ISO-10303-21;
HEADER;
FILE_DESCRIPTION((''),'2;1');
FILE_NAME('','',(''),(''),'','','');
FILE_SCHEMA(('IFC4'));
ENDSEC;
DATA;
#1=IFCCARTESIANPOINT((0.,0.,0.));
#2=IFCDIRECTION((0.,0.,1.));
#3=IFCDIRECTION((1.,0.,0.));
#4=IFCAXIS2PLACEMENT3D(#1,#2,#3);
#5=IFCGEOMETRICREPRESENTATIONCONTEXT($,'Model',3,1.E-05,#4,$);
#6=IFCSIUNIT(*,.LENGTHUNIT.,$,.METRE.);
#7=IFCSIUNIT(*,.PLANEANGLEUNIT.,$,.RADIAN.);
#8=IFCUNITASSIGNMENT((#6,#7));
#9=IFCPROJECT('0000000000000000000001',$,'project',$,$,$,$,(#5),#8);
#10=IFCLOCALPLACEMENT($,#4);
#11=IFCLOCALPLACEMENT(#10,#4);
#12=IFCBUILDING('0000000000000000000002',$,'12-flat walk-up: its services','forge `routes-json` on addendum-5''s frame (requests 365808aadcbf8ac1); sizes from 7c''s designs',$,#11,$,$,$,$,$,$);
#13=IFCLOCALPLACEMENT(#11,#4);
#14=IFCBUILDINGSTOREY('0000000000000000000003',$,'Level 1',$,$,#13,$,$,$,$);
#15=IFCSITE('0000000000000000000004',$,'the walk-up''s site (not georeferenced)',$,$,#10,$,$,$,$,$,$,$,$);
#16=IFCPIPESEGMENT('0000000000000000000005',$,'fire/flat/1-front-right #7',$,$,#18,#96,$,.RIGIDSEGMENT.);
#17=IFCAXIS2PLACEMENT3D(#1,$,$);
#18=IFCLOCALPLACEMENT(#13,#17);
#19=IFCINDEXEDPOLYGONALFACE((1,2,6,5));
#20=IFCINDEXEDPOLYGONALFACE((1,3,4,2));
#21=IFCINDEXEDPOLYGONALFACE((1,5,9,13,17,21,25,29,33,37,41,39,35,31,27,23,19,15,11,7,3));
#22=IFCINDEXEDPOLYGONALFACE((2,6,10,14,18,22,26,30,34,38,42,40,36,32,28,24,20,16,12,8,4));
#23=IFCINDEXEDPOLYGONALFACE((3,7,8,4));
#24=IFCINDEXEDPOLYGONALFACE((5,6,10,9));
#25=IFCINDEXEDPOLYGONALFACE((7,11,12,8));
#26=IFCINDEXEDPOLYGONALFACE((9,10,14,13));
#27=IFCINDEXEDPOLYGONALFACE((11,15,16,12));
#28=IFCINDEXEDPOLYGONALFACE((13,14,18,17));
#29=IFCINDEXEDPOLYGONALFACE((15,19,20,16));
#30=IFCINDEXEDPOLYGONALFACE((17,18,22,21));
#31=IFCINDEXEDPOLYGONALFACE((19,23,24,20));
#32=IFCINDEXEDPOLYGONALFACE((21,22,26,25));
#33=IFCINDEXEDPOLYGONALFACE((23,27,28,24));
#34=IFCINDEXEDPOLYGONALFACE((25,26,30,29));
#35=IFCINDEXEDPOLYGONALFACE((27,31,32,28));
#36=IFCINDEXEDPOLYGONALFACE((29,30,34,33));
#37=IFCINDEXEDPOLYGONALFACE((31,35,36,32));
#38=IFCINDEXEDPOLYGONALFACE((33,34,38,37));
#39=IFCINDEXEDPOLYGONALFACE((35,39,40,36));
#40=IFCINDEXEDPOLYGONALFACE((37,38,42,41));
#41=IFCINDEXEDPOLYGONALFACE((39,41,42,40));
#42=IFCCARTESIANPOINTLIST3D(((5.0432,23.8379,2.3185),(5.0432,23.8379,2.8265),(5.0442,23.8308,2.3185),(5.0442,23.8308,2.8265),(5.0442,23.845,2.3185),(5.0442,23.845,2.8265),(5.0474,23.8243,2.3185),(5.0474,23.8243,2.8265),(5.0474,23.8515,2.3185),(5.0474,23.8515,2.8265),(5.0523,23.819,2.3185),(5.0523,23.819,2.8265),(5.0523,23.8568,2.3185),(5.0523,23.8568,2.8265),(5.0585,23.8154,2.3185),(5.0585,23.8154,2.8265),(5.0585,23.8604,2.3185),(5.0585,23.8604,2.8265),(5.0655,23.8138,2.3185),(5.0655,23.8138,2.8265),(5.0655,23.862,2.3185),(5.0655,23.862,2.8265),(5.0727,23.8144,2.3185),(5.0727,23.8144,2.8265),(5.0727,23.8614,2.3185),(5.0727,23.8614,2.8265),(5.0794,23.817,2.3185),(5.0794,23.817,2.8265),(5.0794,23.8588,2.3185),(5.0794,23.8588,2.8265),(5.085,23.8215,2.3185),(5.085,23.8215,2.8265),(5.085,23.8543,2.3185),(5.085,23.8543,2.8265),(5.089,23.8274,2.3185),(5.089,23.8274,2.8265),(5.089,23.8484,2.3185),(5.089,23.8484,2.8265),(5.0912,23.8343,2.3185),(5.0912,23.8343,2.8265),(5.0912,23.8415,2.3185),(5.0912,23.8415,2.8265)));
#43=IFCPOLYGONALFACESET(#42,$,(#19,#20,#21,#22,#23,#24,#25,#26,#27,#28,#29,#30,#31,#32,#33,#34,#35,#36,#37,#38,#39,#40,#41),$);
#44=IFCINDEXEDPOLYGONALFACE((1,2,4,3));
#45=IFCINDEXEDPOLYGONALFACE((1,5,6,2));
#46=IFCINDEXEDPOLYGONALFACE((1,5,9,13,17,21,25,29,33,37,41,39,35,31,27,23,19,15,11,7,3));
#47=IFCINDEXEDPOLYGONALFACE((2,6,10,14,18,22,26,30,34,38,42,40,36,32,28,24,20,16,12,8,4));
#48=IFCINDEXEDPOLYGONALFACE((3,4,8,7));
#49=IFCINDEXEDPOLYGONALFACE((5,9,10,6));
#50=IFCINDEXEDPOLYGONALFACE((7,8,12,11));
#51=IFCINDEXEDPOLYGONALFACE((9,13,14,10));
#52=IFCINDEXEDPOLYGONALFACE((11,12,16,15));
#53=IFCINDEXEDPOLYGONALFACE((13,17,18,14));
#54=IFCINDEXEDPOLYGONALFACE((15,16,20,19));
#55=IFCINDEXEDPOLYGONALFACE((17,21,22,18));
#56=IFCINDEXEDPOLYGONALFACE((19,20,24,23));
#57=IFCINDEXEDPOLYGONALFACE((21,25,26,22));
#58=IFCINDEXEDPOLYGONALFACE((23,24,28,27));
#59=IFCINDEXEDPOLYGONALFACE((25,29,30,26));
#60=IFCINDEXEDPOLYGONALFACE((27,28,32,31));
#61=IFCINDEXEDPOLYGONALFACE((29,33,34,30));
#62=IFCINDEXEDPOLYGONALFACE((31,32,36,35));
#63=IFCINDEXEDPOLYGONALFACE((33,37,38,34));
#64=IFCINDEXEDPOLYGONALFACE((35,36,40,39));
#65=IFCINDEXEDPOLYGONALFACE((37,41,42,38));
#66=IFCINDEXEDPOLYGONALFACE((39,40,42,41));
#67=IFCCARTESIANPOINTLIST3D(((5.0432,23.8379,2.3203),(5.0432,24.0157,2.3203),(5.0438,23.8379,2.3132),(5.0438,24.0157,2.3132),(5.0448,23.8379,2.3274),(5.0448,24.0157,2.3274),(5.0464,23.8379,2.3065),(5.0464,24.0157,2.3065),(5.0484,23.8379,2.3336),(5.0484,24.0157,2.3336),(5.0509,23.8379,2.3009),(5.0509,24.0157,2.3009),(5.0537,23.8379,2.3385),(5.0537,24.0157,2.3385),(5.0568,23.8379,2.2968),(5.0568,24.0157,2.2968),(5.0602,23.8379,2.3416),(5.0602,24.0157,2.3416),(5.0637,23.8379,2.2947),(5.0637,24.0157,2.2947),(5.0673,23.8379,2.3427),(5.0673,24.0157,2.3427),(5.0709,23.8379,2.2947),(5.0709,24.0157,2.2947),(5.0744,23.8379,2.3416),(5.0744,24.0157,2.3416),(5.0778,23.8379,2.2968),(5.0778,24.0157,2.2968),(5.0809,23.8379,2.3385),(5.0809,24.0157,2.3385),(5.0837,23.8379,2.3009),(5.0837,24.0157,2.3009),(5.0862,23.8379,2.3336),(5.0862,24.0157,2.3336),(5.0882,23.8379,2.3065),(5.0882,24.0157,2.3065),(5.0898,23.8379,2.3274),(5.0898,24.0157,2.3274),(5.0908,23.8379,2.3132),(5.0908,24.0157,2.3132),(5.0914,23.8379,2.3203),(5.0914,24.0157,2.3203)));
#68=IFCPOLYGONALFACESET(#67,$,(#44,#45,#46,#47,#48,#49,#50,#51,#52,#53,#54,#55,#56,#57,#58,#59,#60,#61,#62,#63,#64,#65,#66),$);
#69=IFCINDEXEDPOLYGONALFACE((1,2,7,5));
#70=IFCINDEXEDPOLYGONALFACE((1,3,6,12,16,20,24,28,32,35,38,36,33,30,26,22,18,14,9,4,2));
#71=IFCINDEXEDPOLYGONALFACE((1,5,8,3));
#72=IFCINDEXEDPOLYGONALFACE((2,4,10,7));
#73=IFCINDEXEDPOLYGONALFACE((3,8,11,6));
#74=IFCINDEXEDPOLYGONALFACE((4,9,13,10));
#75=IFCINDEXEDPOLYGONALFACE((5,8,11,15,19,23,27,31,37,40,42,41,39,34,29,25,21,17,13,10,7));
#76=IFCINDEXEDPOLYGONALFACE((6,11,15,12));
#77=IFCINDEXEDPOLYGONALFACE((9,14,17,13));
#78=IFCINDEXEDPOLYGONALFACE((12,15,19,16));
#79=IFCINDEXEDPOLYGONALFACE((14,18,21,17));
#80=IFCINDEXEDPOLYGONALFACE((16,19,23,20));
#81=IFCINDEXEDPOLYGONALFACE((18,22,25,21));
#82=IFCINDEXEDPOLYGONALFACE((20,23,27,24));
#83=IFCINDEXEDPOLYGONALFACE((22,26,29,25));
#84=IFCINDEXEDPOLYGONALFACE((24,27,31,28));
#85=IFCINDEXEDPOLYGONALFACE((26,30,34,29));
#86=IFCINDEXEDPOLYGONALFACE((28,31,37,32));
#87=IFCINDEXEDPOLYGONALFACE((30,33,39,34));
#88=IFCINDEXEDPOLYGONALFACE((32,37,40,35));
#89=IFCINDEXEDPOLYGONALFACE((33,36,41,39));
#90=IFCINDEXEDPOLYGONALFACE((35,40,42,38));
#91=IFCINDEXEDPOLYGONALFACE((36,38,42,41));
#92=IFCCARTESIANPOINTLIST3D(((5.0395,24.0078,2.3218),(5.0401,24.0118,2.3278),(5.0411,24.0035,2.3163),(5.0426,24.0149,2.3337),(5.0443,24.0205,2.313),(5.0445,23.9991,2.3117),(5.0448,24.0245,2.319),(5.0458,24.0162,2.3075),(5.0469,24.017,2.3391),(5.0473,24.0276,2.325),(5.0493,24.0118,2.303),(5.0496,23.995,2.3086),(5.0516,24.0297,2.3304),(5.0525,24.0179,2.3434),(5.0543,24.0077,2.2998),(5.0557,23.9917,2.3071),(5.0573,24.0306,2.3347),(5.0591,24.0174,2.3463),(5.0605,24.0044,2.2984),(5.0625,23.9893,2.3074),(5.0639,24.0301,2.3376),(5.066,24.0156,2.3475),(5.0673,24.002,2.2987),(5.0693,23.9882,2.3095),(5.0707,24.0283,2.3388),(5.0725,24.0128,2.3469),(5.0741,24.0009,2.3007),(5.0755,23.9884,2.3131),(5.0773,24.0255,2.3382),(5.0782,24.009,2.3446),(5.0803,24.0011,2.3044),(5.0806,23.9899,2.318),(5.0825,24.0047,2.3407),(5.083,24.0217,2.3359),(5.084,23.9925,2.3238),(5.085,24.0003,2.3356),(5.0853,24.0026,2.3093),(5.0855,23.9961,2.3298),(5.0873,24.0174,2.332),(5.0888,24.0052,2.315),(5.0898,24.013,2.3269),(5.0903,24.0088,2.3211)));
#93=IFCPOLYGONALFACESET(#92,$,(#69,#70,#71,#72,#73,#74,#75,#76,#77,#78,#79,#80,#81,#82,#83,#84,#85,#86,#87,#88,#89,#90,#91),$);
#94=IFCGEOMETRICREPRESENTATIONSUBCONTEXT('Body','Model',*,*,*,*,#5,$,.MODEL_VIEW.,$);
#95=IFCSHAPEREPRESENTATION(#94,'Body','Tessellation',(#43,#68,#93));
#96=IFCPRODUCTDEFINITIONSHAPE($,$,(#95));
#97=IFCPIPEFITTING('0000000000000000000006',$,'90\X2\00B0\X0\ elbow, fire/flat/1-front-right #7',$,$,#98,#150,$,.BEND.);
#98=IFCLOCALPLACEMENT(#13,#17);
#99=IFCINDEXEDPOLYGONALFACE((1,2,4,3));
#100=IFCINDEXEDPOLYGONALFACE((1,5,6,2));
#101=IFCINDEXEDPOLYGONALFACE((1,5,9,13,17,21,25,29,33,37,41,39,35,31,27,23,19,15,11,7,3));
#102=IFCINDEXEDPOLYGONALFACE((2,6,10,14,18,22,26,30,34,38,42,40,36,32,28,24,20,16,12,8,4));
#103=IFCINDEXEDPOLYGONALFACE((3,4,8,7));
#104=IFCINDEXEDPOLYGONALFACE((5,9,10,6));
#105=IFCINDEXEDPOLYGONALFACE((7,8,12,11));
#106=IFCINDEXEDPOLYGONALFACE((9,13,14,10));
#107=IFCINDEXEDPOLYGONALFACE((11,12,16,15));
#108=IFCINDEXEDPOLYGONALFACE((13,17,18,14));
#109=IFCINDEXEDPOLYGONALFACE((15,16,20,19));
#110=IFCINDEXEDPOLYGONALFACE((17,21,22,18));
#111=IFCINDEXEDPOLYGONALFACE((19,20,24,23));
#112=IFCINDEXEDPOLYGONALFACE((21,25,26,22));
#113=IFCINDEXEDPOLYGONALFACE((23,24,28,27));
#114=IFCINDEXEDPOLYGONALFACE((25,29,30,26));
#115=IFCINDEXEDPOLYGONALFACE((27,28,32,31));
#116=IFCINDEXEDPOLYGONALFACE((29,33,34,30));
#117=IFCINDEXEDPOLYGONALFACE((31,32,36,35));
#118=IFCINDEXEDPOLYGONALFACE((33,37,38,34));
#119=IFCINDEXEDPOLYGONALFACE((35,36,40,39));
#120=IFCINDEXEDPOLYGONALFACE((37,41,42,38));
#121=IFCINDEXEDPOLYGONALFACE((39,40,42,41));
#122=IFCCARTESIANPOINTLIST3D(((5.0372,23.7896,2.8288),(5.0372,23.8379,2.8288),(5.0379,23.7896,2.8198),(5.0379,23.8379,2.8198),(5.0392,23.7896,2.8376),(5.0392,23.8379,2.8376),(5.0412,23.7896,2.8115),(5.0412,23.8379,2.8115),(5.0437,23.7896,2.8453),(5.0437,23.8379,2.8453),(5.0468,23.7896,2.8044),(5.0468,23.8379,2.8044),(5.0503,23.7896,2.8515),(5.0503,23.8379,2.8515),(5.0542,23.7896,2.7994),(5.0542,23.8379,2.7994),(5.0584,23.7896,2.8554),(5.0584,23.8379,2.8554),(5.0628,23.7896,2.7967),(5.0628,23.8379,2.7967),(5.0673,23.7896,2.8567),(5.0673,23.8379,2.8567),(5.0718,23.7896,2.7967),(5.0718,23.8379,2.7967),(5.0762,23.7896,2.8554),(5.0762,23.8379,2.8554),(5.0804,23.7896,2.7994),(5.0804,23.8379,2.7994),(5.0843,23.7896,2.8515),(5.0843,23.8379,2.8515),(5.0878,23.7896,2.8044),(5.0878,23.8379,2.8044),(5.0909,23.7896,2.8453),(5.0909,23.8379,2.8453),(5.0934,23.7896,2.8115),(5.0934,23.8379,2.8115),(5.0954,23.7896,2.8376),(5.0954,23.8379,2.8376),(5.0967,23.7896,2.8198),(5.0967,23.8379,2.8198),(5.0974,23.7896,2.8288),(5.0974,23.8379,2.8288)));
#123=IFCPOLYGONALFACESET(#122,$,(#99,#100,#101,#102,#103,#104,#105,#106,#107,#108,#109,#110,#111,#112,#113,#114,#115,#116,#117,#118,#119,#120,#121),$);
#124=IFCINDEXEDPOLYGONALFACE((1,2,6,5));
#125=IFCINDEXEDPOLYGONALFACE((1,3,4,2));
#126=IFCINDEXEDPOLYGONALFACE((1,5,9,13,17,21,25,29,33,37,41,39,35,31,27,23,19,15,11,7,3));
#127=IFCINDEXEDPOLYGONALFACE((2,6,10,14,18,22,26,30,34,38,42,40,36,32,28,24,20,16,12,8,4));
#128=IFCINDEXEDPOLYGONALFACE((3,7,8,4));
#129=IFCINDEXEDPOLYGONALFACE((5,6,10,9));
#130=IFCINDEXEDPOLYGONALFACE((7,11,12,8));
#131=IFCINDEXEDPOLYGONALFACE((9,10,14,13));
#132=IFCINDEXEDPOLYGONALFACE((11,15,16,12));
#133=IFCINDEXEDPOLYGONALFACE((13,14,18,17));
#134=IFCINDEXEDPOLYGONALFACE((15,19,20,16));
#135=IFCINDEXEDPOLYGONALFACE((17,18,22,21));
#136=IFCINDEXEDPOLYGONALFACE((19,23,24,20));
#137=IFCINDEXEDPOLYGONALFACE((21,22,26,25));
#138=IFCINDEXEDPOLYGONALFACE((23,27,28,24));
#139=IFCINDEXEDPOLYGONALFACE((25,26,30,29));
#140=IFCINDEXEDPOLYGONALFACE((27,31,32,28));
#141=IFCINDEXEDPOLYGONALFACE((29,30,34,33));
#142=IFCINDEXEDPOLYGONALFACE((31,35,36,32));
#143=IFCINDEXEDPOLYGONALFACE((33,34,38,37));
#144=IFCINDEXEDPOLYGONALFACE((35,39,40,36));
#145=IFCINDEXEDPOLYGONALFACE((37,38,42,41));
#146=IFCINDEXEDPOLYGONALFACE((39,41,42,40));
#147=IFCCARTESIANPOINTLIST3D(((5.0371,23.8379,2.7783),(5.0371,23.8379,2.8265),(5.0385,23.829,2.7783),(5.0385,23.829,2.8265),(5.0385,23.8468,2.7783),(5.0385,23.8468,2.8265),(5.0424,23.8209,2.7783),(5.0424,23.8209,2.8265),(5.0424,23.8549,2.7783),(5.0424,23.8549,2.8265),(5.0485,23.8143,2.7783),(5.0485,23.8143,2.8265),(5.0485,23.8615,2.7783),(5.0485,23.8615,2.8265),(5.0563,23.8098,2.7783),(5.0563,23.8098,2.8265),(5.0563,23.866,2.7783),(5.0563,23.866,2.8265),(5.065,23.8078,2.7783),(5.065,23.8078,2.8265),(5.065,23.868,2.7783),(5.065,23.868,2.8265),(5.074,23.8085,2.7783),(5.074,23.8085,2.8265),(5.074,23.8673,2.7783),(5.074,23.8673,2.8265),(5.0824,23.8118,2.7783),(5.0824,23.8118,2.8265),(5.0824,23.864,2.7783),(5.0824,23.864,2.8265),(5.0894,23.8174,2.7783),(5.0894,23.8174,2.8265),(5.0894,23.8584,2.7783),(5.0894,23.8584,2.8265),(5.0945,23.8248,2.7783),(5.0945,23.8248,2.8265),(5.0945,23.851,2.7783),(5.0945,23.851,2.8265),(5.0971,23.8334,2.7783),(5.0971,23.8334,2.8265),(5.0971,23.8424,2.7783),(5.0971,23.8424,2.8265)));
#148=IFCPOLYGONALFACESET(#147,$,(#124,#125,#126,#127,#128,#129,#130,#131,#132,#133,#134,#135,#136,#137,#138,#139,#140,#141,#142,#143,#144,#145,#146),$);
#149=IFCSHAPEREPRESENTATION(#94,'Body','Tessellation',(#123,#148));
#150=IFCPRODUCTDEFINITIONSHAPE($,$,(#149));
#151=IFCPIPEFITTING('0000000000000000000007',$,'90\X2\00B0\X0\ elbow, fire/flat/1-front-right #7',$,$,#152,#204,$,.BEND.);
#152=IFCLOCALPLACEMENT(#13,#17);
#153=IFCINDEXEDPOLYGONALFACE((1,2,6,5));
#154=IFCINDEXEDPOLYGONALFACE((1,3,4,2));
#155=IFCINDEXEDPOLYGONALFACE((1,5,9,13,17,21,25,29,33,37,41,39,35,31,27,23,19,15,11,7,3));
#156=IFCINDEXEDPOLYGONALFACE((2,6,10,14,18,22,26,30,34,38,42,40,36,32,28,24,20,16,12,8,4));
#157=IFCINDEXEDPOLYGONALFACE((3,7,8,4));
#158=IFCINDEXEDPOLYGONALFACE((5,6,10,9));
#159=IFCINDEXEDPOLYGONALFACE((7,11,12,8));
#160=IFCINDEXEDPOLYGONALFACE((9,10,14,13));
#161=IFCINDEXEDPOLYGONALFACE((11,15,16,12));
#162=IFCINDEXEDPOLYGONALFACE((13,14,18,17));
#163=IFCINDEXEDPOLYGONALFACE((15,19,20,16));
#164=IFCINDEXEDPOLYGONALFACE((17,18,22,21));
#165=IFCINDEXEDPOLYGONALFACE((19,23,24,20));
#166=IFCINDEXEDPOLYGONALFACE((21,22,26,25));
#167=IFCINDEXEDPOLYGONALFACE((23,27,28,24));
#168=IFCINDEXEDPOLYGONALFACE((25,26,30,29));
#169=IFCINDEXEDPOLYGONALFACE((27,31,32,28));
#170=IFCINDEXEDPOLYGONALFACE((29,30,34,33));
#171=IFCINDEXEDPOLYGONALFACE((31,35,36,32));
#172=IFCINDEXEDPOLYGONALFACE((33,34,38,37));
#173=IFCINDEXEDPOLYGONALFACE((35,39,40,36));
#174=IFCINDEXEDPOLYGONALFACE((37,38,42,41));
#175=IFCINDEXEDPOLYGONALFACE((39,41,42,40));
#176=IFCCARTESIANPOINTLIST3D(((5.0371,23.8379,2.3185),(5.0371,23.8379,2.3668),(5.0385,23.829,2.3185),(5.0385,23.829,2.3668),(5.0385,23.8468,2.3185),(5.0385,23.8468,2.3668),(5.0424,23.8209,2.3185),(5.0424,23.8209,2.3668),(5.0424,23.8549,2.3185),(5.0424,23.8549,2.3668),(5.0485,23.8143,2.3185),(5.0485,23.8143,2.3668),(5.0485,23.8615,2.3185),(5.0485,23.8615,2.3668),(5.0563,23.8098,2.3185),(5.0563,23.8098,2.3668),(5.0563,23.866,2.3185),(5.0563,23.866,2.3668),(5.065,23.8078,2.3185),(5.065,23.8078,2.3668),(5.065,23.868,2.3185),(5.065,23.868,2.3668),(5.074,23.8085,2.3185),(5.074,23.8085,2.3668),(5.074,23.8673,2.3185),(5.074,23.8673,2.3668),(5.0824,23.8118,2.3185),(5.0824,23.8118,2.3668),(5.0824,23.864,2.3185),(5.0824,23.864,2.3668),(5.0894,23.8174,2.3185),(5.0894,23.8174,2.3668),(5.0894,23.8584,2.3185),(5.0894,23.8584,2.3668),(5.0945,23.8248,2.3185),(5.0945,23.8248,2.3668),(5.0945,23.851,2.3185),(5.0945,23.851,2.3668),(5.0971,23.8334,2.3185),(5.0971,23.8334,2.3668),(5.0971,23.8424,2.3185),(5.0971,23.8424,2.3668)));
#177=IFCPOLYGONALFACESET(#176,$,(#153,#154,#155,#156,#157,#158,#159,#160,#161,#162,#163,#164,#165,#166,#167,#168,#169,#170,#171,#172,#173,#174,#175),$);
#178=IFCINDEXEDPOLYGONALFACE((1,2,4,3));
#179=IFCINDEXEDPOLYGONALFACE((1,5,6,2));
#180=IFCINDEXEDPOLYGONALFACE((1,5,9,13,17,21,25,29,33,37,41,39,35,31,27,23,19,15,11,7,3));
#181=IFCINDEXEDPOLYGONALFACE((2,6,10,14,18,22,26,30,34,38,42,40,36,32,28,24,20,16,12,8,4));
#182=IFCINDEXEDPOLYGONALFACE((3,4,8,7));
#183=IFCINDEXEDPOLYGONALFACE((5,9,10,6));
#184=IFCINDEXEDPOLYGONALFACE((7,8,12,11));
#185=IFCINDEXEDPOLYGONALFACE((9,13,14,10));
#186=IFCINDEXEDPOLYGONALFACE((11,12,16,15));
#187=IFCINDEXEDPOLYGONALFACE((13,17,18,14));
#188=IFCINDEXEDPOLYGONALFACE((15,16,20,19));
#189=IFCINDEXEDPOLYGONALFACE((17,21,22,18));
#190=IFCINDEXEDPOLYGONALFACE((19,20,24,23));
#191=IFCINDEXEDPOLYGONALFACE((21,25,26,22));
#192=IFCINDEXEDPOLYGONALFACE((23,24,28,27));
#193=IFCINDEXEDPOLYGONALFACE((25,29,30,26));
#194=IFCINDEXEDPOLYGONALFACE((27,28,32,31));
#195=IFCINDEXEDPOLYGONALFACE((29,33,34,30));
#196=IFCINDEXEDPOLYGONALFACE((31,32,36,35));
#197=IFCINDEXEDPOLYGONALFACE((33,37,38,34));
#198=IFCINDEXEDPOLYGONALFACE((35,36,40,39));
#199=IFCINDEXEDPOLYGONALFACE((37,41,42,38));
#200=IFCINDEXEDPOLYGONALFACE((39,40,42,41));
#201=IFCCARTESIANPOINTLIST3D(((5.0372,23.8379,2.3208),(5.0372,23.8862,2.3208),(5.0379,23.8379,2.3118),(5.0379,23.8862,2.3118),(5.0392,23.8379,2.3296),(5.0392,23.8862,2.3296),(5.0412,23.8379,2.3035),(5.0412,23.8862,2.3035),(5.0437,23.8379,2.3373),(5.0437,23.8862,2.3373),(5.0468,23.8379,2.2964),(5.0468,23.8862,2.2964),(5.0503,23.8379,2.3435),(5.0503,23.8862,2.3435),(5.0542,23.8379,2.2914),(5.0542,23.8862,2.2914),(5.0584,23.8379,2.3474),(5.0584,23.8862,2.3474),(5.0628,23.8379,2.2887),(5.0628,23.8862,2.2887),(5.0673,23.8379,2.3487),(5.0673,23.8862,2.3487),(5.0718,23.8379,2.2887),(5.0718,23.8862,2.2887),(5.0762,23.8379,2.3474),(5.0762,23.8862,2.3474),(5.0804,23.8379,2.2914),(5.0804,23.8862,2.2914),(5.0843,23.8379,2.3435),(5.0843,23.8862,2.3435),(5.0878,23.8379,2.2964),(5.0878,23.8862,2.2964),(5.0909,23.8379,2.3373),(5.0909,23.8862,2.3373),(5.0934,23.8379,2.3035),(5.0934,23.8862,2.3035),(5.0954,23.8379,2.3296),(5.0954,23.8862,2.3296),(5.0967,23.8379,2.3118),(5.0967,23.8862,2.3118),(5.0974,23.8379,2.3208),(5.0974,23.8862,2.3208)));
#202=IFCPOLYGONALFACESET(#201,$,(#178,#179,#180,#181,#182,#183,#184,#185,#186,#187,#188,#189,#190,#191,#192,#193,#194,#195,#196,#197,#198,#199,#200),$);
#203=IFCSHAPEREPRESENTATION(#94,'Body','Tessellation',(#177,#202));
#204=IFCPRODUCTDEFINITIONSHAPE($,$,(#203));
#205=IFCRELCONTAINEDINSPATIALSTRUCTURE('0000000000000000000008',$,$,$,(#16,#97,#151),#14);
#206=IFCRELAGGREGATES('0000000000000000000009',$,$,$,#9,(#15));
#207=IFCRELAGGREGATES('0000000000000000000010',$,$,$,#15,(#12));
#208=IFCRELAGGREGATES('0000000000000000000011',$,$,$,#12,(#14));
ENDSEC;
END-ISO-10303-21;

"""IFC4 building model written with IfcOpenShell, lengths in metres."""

from ifc_helpers import new_model, entity, si_unit, frame, origin_with_axes, place, context, subcontext, project, spatial, element, save


model = new_model("IFC4")

# Units and contexts
model_context = context("Model", 3, precision=1e-05, world=origin_with_axes())
body_context = subcontext(model_context, "Body", "Model", "MODEL_VIEW")
ifc_project = project(units=[si_unit("LENGTHUNIT", "METRE"), si_unit("PLANEANGLEUNIT", "RADIAN")], contexts=[model_context])

# Site, building, storey
site_placement = place(None, origin_with_axes())
site = spatial("IfcSite", under=ifc_project, at=site_placement, Name="the walk-up's site (not georeferenced)")
building_placement = place(site_placement, origin_with_axes())
building = spatial("IfcBuilding", under=site, at=building_placement, Name="12-flat walk-up: its services", Description="forge `routes-json` on addendum-5's frame (requests 365808aadcbf8ac1); sizes from 7c's designs")
storey_placement = place(building_placement, origin_with_axes())
storey = spatial("IfcBuildingStorey", under=building, at=storey_placement, Name="Level 1")

# Pipe segment
pipe_segment_1_placement = place(storey_placement, frame((5.0673, 23.8379, 2.8265), z_axis=(0.0, 0.0, 1.0), x_axis=(1.0, 0.0, 0.0)))
element("IfcPipeSegment", 1, at=pipe_segment_1_placement, inside=storey, Name="fire/flat/1-front-right #7", PredefinedType="RIGIDSEGMENT", context=body_context, shape_type="AdvancedSweptSolid", body=[
    entity("IfcSweptDiskSolid", entity("IfcPolyline", [entity("IfcCartesianPoint", [0.0, 0.0, 0.0]), entity("IfcCartesianPoint", [0.0, 0.0, -0.508])]), 0.0241),
    entity("IfcSweptDiskSolid", entity("IfcPolyline", [entity("IfcCartesianPoint", [0.0, 0.0, -0.508]), entity("IfcCartesianPoint", [0.0, 0.1778, -0.508])]), 0.0241),
    entity("IfcSweptDiskSolid", entity("IfcPolyline", [entity("IfcCartesianPoint", [0.0, 0.1778, -0.508]), entity("IfcCartesianPoint", [-0.0048, 0.1651, -0.4993])]), 0.0241),
])

# Pipe fittings
pipe_fitting_1_placement = place(storey_placement, frame((5.0673, 23.7896, 2.8265), z_axis=(0.0, 0.0, 1.0), x_axis=(1.0, 0.0, 0.0)))
element("IfcPipeFitting", 2, at=pipe_fitting_1_placement, inside=storey, Name="90° elbow, fire/flat/1-front-right #7", PredefinedType="BEND", context=body_context, shape_type="AdvancedSweptSolid", body=[
    entity("IfcSweptDiskSolid", entity("IfcPolyline", [entity("IfcCartesianPoint", [0.0, 0.0, 0.0]), entity("IfcCartesianPoint", [0.0, 0.0483, 0.0])]), 0.0302),
    entity("IfcSweptDiskSolid", entity("IfcPolyline", [entity("IfcCartesianPoint", [0.0, 0.0483, 0.0]), entity("IfcCartesianPoint", [0.0, 0.0483, -0.0483])]), 0.0302),
])
pipe_fitting_2_placement = place(storey_placement, frame((5.0673, 23.8379, 2.3668), z_axis=(0.0, 0.0, 1.0), x_axis=(1.0, 0.0, 0.0)))
element("IfcPipeFitting", 3, at=pipe_fitting_2_placement, inside=storey, Name="90° elbow, fire/flat/1-front-right #7", PredefinedType="BEND", context=body_context, shape_type="AdvancedSweptSolid", body=[
    entity("IfcSweptDiskSolid", entity("IfcPolyline", [entity("IfcCartesianPoint", [0.0, 0.0, 0.0]), entity("IfcCartesianPoint", [0.0, 0.0, -0.0483])]), 0.0302),
    entity("IfcSweptDiskSolid", entity("IfcPolyline", [entity("IfcCartesianPoint", [0.0, 0.0, -0.0483]), entity("IfcCartesianPoint", [0.0, 0.0483, -0.0483])]), 0.0302),
])

save(model, "model.ifc")
